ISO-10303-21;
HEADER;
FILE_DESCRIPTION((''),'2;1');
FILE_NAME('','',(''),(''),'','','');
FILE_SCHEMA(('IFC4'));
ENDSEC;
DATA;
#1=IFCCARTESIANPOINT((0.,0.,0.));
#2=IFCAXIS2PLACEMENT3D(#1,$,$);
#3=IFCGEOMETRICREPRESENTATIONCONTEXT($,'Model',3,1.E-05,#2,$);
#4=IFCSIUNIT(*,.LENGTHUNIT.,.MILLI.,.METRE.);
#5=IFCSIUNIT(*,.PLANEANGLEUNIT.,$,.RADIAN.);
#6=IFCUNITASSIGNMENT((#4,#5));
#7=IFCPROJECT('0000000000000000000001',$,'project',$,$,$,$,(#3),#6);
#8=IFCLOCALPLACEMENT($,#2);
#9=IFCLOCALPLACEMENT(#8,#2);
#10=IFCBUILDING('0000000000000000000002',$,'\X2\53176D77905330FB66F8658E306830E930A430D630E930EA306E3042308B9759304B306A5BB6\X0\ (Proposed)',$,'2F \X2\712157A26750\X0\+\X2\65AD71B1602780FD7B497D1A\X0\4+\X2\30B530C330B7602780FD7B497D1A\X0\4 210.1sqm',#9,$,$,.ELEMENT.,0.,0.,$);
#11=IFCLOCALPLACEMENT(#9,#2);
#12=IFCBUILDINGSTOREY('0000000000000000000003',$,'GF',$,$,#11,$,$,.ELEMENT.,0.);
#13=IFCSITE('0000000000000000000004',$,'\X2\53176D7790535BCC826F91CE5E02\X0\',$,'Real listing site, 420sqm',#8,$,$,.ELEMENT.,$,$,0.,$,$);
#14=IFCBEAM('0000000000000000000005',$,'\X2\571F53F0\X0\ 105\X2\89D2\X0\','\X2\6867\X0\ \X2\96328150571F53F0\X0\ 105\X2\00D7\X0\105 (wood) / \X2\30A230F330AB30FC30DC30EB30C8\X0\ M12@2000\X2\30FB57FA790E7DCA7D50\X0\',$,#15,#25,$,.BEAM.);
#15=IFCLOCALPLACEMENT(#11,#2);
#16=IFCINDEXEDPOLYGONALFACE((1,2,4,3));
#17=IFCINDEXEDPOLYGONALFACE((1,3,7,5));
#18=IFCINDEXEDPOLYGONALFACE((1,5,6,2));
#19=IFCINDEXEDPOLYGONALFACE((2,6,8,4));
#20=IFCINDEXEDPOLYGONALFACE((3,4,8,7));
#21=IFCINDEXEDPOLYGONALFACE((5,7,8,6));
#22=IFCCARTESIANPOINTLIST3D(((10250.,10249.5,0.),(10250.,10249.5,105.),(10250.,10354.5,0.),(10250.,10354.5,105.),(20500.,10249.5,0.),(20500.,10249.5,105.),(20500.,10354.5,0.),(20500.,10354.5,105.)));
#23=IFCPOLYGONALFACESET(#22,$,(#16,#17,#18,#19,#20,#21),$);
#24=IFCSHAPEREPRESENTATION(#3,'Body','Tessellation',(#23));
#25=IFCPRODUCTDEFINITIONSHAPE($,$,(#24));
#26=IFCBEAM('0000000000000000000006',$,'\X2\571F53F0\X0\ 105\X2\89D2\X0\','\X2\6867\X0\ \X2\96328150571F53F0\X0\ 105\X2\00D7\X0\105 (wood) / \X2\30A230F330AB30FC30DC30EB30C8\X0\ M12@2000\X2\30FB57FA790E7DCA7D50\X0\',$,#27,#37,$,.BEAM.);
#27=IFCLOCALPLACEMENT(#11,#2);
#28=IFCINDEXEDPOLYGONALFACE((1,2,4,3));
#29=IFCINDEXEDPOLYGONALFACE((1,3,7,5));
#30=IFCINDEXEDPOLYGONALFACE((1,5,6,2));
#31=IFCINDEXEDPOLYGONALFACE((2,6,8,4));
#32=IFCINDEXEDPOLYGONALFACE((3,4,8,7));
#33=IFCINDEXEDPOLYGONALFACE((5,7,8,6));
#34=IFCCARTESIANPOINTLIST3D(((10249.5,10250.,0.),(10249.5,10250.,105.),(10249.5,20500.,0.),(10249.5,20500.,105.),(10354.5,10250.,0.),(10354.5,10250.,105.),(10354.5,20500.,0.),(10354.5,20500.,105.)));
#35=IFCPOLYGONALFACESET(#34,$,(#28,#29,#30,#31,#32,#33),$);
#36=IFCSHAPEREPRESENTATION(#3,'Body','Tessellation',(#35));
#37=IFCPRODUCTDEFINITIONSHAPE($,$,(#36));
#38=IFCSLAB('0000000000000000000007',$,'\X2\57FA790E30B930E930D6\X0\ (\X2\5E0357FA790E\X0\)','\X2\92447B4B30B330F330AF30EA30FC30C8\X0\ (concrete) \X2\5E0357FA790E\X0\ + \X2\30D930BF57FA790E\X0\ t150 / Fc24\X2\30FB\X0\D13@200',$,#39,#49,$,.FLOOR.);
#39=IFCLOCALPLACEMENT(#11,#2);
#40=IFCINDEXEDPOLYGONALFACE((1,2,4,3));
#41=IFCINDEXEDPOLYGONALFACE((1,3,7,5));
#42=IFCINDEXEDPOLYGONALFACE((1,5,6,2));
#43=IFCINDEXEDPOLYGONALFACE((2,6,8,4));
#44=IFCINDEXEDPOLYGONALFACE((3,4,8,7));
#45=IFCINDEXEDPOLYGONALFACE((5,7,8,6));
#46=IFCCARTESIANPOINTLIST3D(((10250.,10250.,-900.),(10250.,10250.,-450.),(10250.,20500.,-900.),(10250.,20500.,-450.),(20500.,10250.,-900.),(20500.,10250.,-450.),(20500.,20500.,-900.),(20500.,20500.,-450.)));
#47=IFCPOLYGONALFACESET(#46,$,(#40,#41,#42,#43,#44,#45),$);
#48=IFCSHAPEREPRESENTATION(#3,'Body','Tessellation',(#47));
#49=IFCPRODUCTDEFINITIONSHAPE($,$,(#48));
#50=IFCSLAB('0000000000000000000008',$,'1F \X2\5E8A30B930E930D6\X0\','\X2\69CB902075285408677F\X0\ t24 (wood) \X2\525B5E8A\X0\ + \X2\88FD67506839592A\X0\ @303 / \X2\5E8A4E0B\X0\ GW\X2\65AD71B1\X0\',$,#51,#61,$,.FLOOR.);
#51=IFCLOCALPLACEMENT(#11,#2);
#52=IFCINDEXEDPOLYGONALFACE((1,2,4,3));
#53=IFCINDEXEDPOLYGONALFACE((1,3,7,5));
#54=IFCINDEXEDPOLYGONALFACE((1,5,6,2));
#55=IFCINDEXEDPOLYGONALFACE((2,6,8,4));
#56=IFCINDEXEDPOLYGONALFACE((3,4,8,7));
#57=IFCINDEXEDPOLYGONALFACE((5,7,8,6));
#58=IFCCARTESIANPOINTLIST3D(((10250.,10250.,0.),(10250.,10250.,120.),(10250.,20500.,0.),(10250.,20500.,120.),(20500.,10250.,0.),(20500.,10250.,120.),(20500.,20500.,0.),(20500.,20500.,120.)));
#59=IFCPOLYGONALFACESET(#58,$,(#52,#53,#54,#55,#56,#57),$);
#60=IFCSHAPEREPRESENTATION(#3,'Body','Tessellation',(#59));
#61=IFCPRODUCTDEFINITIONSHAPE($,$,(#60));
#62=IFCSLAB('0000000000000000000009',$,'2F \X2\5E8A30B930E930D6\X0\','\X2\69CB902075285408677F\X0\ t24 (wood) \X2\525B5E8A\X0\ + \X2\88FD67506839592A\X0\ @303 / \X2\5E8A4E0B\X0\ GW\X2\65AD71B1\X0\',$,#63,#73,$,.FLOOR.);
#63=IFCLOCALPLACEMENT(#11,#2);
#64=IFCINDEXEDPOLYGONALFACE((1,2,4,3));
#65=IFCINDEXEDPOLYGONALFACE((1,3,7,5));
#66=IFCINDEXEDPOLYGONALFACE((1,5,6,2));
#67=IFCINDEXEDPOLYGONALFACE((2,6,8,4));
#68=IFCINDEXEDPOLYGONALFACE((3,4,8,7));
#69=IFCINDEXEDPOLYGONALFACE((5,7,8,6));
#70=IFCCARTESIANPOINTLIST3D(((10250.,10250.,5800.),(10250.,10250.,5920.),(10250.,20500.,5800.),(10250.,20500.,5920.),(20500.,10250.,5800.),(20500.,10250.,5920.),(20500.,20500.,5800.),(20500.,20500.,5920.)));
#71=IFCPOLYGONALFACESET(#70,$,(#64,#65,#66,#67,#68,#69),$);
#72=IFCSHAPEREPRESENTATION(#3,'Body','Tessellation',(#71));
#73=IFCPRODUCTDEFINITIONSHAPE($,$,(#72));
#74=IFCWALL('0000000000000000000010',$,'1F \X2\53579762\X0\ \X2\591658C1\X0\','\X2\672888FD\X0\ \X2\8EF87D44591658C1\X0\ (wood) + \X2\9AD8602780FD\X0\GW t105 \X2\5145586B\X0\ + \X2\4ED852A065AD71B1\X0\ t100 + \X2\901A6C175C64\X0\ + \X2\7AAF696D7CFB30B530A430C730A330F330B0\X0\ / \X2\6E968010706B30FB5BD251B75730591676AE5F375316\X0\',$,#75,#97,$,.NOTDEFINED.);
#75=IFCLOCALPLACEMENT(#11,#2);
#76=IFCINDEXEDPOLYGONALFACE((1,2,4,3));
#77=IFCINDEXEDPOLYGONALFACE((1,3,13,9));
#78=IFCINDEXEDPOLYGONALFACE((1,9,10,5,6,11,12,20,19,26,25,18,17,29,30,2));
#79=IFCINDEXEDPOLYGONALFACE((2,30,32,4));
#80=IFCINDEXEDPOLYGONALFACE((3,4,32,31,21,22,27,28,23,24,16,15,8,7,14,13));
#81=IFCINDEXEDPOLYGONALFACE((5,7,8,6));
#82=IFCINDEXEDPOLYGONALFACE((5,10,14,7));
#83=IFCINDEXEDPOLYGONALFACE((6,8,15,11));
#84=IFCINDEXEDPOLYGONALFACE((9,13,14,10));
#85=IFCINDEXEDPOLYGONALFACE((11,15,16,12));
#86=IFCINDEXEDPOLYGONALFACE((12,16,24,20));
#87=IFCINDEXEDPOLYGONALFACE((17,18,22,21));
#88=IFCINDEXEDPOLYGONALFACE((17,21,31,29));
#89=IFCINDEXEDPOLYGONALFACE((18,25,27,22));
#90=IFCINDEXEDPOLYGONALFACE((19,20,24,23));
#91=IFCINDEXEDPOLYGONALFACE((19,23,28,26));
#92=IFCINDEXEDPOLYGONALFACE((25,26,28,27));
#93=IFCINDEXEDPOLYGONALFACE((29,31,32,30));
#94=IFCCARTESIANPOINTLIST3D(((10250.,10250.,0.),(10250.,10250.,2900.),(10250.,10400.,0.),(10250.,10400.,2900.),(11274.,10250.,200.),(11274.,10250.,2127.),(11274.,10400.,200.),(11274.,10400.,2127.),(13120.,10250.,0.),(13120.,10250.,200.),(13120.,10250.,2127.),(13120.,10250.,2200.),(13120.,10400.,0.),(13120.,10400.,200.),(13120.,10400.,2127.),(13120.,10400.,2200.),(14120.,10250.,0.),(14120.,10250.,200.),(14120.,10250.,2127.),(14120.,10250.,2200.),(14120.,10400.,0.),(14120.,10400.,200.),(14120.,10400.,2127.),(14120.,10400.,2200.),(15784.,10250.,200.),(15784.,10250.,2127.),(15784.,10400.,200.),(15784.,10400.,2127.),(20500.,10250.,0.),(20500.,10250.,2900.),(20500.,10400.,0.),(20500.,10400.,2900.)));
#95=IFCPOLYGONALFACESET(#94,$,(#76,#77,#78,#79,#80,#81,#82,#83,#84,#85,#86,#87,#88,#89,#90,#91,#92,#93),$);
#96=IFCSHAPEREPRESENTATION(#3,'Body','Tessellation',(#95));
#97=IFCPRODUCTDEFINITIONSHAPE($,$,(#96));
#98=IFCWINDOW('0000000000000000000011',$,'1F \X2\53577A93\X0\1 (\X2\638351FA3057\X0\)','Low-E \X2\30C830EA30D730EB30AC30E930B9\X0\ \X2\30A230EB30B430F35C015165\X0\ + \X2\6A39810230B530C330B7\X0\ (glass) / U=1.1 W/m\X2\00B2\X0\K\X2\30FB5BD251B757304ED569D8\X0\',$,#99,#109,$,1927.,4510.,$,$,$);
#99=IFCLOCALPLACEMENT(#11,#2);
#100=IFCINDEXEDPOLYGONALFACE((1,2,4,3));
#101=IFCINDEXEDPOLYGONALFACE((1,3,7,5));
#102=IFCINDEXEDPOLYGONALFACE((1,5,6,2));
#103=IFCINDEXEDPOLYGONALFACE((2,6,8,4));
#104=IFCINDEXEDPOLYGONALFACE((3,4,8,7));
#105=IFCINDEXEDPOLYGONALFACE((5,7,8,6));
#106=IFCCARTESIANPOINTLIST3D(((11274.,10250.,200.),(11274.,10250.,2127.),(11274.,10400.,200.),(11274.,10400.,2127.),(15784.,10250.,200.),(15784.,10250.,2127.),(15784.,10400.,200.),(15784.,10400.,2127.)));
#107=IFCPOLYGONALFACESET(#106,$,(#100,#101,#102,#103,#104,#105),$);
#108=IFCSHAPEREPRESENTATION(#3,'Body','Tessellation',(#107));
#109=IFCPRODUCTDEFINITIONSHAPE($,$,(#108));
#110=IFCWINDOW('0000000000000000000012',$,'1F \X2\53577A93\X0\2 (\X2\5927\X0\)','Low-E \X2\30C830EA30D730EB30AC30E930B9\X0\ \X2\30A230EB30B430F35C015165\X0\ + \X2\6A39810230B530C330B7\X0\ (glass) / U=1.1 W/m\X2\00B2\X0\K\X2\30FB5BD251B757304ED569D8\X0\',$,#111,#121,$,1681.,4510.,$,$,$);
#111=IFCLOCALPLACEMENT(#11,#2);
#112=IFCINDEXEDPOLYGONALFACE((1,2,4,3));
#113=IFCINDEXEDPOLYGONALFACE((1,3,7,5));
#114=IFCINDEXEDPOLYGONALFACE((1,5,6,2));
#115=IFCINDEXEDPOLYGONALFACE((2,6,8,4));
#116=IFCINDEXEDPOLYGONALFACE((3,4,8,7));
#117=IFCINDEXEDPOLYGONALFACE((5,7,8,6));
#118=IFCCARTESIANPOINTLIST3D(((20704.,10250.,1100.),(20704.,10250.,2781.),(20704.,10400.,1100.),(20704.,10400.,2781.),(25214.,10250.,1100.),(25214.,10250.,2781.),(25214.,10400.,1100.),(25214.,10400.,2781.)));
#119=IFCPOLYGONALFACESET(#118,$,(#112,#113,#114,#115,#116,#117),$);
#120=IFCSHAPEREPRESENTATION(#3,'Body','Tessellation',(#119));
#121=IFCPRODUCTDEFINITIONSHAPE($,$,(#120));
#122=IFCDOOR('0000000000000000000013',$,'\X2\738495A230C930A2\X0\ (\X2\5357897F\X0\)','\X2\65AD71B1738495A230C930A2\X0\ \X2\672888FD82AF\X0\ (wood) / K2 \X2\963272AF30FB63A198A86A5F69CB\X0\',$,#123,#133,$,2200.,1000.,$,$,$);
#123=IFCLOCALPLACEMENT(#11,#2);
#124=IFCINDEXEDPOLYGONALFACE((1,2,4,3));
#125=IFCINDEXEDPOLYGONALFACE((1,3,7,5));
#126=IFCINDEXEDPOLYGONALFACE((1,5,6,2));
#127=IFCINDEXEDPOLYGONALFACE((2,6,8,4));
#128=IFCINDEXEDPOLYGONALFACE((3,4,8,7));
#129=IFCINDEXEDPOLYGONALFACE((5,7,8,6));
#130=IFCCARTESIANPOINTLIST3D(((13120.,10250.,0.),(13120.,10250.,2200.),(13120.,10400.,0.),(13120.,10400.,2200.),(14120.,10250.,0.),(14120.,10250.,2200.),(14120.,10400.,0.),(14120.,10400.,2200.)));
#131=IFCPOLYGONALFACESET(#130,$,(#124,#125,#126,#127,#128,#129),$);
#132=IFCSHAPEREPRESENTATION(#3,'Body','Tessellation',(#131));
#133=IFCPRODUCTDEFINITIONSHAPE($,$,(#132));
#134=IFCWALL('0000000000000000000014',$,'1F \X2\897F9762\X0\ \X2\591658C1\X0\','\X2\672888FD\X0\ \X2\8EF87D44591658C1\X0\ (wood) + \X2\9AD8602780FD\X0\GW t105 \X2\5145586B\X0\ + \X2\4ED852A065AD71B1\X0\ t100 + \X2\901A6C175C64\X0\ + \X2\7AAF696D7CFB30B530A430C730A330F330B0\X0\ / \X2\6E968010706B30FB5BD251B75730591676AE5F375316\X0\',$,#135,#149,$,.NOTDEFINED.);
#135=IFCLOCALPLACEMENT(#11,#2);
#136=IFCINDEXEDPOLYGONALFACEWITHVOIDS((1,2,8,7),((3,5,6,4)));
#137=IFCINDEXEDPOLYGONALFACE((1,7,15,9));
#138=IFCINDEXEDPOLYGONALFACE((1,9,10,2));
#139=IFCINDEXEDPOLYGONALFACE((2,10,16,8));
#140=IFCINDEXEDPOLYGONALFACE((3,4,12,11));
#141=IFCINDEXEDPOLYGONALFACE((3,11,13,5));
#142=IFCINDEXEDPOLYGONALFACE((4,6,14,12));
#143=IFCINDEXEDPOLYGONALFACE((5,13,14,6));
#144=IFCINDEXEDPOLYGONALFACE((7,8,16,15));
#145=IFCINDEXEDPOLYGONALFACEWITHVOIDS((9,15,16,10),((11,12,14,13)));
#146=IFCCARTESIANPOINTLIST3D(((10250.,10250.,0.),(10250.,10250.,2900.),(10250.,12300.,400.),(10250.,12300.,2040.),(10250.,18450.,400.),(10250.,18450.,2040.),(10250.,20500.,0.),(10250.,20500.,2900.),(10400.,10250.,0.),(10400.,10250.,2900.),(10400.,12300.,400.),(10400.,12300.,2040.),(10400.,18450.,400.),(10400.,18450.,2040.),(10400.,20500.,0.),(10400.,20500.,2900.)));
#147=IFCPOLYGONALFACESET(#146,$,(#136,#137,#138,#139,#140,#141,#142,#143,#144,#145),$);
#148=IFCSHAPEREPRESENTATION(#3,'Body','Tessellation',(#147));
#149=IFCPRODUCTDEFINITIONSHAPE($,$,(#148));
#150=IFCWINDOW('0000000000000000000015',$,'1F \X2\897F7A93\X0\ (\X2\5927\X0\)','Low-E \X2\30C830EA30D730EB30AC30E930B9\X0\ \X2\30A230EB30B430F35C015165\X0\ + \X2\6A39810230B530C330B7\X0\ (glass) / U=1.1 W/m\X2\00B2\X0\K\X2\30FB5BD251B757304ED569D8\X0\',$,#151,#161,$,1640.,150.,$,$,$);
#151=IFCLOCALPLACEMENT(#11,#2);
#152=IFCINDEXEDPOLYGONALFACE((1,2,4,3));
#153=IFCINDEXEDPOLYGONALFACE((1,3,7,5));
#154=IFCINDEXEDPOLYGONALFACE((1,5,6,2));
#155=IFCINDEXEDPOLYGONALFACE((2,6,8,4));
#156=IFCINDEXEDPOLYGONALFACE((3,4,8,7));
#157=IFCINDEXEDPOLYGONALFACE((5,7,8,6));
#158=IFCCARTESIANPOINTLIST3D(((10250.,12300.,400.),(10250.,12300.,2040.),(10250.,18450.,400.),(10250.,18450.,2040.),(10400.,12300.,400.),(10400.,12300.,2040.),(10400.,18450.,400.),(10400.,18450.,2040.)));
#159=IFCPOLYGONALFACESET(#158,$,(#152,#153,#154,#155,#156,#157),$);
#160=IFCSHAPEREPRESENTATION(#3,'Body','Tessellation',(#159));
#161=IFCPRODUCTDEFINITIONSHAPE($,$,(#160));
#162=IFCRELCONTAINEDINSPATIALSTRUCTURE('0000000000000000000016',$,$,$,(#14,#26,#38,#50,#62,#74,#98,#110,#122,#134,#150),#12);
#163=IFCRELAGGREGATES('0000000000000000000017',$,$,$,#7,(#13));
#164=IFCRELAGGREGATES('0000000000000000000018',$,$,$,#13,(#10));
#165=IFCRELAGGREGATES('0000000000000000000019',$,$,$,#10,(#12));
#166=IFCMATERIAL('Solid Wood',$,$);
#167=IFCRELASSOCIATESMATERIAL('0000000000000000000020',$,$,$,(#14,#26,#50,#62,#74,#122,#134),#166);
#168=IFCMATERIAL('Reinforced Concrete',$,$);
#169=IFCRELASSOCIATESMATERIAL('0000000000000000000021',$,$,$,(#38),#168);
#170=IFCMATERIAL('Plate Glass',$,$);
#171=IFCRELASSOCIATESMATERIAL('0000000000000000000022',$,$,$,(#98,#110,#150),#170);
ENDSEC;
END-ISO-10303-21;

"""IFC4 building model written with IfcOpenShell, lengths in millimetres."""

from ifc_helpers import new_model, si_unit, frame, frame_2d, origin, place, context, project, spatial, rectangle, extrude, material, element, fill, save


model = new_model("IFC4")

# Units and contexts
model_context = context("Model", 3, precision=1e-05, world=origin())
ifc_project = project(units=[si_unit("LENGTHUNIT", "METRE", prefix="MILLI"), si_unit("PLANEANGLEUNIT", "RADIAN")], contexts=[model_context])

# Site, building, storey
site_placement = place(None, origin())
site = spatial("IfcSite", under=ifc_project, at=site_placement, Name="北海道富良野市", ObjectType="Real listing site, 420sqm", CompositionType="ELEMENT", RefElevation=0.0)
building_placement = place(site_placement, origin())
building = spatial("IfcBuilding", under=site, at=building_placement, Name="北海道・書斎とライブラリのある静かな家 (Proposed)", ObjectType="2F 無垢材+断熱性能等級4+サッシ性能等級4 210.1sqm", CompositionType="ELEMENT", ElevationOfRefHeight=0.0, ElevationOfTerrain=0.0)
storey_placement = place(building_placement, origin())
storey = spatial("IfcBuildingStorey", under=building, at=storey_placement, Name="GF", CompositionType="ELEMENT", Elevation=0.0)

# Shared definitions
ifc_material_1 = material(Name="Solid Wood")

# Beams
beam_1_placement = place(storey_placement, frame((5125.0, 5125.0, 0.0)))
element("IfcBeam", 1, at=beam_1_placement, inside=storey, material=ifc_material_1, Name="土台 105角", Description="桧 防腐土台 105×105 (wood) / アンカーボルト M12@2000・基礎緊結", PredefinedType="BEAM", context=model_context, shape_type="SweptSolid", body=[
    extrude(rectangle(XDim=10250.0, YDim=105.0, at=frame_2d((5125.0, 52.0))), frame((5125.0, 5125.0, 0.0)), (0.0, 0.0, 1.0), 105.0),
])
beam_2_placement = place(storey_placement, frame((5125.0, 5125.0, 0.0)))
element("IfcBeam", 2, at=beam_2_placement, inside=storey, material=ifc_material_1, Name="土台 105角", Description="桧 防腐土台 105×105 (wood) / アンカーボルト M12@2000・基礎緊結", PredefinedType="BEAM", context=model_context, shape_type="SweptSolid", body=[
    extrude(rectangle(XDim=105.0, YDim=10250.0, at=frame_2d((52.0, 5125.0))), frame((5125.0, 5125.0, 0.0)), (0.0, 0.0, 1.0), 105.0),
])

# Slabs
ifc_material_2 = material(Name="Reinforced Concrete")
slab_1_placement = place(storey_placement, frame((5125.0, 5125.0, -450.0)))
element("IfcSlab", 3, at=slab_1_placement, inside=storey, material=ifc_material_2, Name="基礎スラブ (布基礎)", Description="鉄筋コンクリート (concrete) 布基礎 + ベタ基礎 t150 / Fc24・D13@200", PredefinedType="FLOOR", context=model_context, shape_type="SweptSolid", body=[
    extrude(rectangle(XDim=10250.0, YDim=10250.0, at=frame_2d((5125.0, 5125.0))), frame((5125.0, 5125.0, -450.0)), (0.0, 0.0, 1.0), 450.0),
])
slab_2_placement = place(storey_placement, frame((5125.0, 5125.0, 0.0)))
element("IfcSlab", 4, at=slab_2_placement, inside=storey, material=ifc_material_1, Name="1F 床スラブ", Description="構造用合板 t24 (wood) 剛床 + 製材根太 @303 / 床下 GW断熱", PredefinedType="FLOOR", context=model_context, shape_type="SweptSolid", body=[
    extrude(rectangle(XDim=10250.0, YDim=10250.0, at=frame_2d((5125.0, 5125.0))), frame((5125.0, 5125.0, 0.0)), (0.0, 0.0, 1.0), 120.0),
])
slab_3_placement = place(storey_placement, frame((5125.0, 5125.0, 2900.0)))
element("IfcSlab", 5, at=slab_3_placement, inside=storey, material=ifc_material_1, Name="2F 床スラブ", Description="構造用合板 t24 (wood) 剛床 + 製材根太 @303 / 床下 GW断熱", PredefinedType="FLOOR", context=model_context, shape_type="SweptSolid", body=[
    extrude(rectangle(XDim=10250.0, YDim=10250.0, at=frame_2d((5125.0, 5125.0))), frame((5125.0, 5125.0, 2900.0)), (0.0, 0.0, 1.0), 120.0),
])

# Wall, openings, windows, door
wall_1_placement = place(storey_placement, frame((5125.0, 5125.0, 0.0)))
wall_1 = element("IfcWall", 6, at=wall_1_placement, inside=storey, material=ifc_material_1, Name="1F 南面 外壁", Description="木製 軸組外壁 (wood) + 高性能GW t105 充填 + 付加断熱 t100 + 通気層 + 窯業系サイディング / 準耐火・寒冷地外皮強化", PredefinedType="NOTDEFINED", context=model_context, shape_type="SweptSolid", body=[
    extrude(rectangle(XDim=10250.0, YDim=150.0, at=frame_2d((5125.0, 75.0))), frame((5125.0, 5125.0, 0.0)), (0.0, 0.0, 1.0), 2900.0),
])
opening_1_placement = place(storey_placement, frame((5637.0, 5125.0, 100.0)))
opening_1 = element("IfcOpeningElement", 7, at=opening_1_placement, cuts=wall_1, PredefinedType="NOTDEFINED", context=model_context, shape_type="SweptSolid", body=[
    extrude(rectangle(XDim=4510.0, YDim=150.0, at=frame_2d((2255.0, 75.0))), frame((5637.0, 5125.0, 100.0)), (0.0, 0.0, 1.0), 1927.0),
])
opening_2_placement = place(storey_placement, frame((10352.0, 5125.0, 550.0)))
opening_2 = element("IfcOpeningElement", 8, at=opening_2_placement, cuts=wall_1, PredefinedType="NOTDEFINED", context=model_context, shape_type="SweptSolid", body=[
    extrude(rectangle(XDim=4510.0, YDim=150.0, at=frame_2d((2255.0, 75.0))), frame((10352.0, 5125.0, 550.0)), (0.0, 0.0, 1.0), 1681.0),
])
opening_3_placement = place(storey_placement, frame((6560.0, 5125.0, 0.0)))
opening_3 = element("IfcOpeningElement", 9, at=opening_3_placement, cuts=wall_1, PredefinedType="NOTDEFINED", context=model_context, shape_type="SweptSolid", body=[
    extrude(rectangle(XDim=1000.0, YDim=150.0, at=frame_2d((500.0, 75.0))), frame((6560.0, 5125.0, 0.0)), (0.0, 0.0, 1.0), 2200.0),
])
ifc_material_3 = material(Name="Plate Glass")
window_1_placement = place(storey_placement, frame((5637.0, 5125.0, 100.0)))
window_1 = element("IfcWindow", 10, at=window_1_placement, inside=storey, material=ifc_material_3, Name="1F 南窓1 (掃出し)", Description="Low-E トリプルガラス アルゴン封入 + 樹脂サッシ (glass) / U=1.1 W/m²K・寒冷地仕様", OverallHeight=1927.0, OverallWidth=4510.0, context=model_context, shape_type="SweptSolid", body=[
    extrude(rectangle(XDim=4510.0, YDim=150.0, at=frame_2d((2255.0, 75.0))), frame((5637.0, 5125.0, 100.0)), (0.0, 0.0, 1.0), 1927.0),
])
fill(opening_1, window_1)
window_2_placement = place(storey_placement, frame((10352.0, 5125.0, 550.0)))
window_2 = element("IfcWindow", 11, at=window_2_placement, inside=storey, material=ifc_material_3, Name="1F 南窓2 (大)", Description="Low-E トリプルガラス アルゴン封入 + 樹脂サッシ (glass) / U=1.1 W/m²K・寒冷地仕様", OverallHeight=1681.0, OverallWidth=4510.0, context=model_context, shape_type="SweptSolid", body=[
    extrude(rectangle(XDim=4510.0, YDim=150.0, at=frame_2d((2255.0, 75.0))), frame((10352.0, 5125.0, 550.0)), (0.0, 0.0, 1.0), 1681.0),
])
fill(opening_2, window_2)
door_placement = place(storey_placement, frame((6560.0, 5125.0, 0.0)))
door = element("IfcDoor", 12, at=door_placement, inside=storey, material=ifc_material_1, Name="玄関ドア (南西)", Description="断熱玄関ドア 木製芯 (wood) / K2 防犯・採風機構", OverallHeight=2200.0, OverallWidth=1000.0, context=model_context, shape_type="SweptSolid", body=[
    extrude(rectangle(XDim=1000.0, YDim=150.0, at=frame_2d((500.0, 75.0))), frame((6560.0, 5125.0, 0.0)), (0.0, 0.0, 1.0), 2200.0),
])
fill(opening_3, door)

# Wall, opening, window
wall_2_placement = place(storey_placement, frame((5125.0, 5125.0, 0.0)))
wall_2 = element("IfcWall", 13, at=wall_2_placement, inside=storey, material=ifc_material_1, Name="1F 西面 外壁", Description="木製 軸組外壁 (wood) + 高性能GW t105 充填 + 付加断熱 t100 + 通気層 + 窯業系サイディング / 準耐火・寒冷地外皮強化", PredefinedType="NOTDEFINED", context=model_context, shape_type="SweptSolid", body=[
    extrude(rectangle(XDim=150.0, YDim=10250.0, at=frame_2d((75.0, 5125.0))), frame((5125.0, 5125.0, 0.0)), (0.0, 0.0, 1.0), 2900.0),
])
opening_4_placement = place(storey_placement, frame((5125.0, 6150.0, 200.0)))
opening_4 = element("IfcOpeningElement", 14, at=opening_4_placement, cuts=wall_2, PredefinedType="NOTDEFINED", context=model_context, shape_type="SweptSolid", body=[
    extrude(rectangle(XDim=150.0, YDim=6150.0, at=frame_2d((75.0, 3075.0))), frame((5125.0, 6150.0, 200.0)), (0.0, 0.0, 1.0), 1640.0),
])
window_3_placement = place(storey_placement, frame((5125.0, 6150.0, 200.0)))
window_3 = element("IfcWindow", 15, at=window_3_placement, inside=storey, material=ifc_material_3, Name="1F 西窓 (大)", Description="Low-E トリプルガラス アルゴン封入 + 樹脂サッシ (glass) / U=1.1 W/m²K・寒冷地仕様", OverallHeight=1640.0, OverallWidth=150.0, context=model_context, shape_type="SweptSolid", body=[
    extrude(rectangle(XDim=150.0, YDim=6150.0, at=frame_2d((75.0, 3075.0))), frame((5125.0, 6150.0, 200.0)), (0.0, 0.0, 1.0), 1640.0),
])
fill(opening_4, window_3)

save(model, "model.ifc")
